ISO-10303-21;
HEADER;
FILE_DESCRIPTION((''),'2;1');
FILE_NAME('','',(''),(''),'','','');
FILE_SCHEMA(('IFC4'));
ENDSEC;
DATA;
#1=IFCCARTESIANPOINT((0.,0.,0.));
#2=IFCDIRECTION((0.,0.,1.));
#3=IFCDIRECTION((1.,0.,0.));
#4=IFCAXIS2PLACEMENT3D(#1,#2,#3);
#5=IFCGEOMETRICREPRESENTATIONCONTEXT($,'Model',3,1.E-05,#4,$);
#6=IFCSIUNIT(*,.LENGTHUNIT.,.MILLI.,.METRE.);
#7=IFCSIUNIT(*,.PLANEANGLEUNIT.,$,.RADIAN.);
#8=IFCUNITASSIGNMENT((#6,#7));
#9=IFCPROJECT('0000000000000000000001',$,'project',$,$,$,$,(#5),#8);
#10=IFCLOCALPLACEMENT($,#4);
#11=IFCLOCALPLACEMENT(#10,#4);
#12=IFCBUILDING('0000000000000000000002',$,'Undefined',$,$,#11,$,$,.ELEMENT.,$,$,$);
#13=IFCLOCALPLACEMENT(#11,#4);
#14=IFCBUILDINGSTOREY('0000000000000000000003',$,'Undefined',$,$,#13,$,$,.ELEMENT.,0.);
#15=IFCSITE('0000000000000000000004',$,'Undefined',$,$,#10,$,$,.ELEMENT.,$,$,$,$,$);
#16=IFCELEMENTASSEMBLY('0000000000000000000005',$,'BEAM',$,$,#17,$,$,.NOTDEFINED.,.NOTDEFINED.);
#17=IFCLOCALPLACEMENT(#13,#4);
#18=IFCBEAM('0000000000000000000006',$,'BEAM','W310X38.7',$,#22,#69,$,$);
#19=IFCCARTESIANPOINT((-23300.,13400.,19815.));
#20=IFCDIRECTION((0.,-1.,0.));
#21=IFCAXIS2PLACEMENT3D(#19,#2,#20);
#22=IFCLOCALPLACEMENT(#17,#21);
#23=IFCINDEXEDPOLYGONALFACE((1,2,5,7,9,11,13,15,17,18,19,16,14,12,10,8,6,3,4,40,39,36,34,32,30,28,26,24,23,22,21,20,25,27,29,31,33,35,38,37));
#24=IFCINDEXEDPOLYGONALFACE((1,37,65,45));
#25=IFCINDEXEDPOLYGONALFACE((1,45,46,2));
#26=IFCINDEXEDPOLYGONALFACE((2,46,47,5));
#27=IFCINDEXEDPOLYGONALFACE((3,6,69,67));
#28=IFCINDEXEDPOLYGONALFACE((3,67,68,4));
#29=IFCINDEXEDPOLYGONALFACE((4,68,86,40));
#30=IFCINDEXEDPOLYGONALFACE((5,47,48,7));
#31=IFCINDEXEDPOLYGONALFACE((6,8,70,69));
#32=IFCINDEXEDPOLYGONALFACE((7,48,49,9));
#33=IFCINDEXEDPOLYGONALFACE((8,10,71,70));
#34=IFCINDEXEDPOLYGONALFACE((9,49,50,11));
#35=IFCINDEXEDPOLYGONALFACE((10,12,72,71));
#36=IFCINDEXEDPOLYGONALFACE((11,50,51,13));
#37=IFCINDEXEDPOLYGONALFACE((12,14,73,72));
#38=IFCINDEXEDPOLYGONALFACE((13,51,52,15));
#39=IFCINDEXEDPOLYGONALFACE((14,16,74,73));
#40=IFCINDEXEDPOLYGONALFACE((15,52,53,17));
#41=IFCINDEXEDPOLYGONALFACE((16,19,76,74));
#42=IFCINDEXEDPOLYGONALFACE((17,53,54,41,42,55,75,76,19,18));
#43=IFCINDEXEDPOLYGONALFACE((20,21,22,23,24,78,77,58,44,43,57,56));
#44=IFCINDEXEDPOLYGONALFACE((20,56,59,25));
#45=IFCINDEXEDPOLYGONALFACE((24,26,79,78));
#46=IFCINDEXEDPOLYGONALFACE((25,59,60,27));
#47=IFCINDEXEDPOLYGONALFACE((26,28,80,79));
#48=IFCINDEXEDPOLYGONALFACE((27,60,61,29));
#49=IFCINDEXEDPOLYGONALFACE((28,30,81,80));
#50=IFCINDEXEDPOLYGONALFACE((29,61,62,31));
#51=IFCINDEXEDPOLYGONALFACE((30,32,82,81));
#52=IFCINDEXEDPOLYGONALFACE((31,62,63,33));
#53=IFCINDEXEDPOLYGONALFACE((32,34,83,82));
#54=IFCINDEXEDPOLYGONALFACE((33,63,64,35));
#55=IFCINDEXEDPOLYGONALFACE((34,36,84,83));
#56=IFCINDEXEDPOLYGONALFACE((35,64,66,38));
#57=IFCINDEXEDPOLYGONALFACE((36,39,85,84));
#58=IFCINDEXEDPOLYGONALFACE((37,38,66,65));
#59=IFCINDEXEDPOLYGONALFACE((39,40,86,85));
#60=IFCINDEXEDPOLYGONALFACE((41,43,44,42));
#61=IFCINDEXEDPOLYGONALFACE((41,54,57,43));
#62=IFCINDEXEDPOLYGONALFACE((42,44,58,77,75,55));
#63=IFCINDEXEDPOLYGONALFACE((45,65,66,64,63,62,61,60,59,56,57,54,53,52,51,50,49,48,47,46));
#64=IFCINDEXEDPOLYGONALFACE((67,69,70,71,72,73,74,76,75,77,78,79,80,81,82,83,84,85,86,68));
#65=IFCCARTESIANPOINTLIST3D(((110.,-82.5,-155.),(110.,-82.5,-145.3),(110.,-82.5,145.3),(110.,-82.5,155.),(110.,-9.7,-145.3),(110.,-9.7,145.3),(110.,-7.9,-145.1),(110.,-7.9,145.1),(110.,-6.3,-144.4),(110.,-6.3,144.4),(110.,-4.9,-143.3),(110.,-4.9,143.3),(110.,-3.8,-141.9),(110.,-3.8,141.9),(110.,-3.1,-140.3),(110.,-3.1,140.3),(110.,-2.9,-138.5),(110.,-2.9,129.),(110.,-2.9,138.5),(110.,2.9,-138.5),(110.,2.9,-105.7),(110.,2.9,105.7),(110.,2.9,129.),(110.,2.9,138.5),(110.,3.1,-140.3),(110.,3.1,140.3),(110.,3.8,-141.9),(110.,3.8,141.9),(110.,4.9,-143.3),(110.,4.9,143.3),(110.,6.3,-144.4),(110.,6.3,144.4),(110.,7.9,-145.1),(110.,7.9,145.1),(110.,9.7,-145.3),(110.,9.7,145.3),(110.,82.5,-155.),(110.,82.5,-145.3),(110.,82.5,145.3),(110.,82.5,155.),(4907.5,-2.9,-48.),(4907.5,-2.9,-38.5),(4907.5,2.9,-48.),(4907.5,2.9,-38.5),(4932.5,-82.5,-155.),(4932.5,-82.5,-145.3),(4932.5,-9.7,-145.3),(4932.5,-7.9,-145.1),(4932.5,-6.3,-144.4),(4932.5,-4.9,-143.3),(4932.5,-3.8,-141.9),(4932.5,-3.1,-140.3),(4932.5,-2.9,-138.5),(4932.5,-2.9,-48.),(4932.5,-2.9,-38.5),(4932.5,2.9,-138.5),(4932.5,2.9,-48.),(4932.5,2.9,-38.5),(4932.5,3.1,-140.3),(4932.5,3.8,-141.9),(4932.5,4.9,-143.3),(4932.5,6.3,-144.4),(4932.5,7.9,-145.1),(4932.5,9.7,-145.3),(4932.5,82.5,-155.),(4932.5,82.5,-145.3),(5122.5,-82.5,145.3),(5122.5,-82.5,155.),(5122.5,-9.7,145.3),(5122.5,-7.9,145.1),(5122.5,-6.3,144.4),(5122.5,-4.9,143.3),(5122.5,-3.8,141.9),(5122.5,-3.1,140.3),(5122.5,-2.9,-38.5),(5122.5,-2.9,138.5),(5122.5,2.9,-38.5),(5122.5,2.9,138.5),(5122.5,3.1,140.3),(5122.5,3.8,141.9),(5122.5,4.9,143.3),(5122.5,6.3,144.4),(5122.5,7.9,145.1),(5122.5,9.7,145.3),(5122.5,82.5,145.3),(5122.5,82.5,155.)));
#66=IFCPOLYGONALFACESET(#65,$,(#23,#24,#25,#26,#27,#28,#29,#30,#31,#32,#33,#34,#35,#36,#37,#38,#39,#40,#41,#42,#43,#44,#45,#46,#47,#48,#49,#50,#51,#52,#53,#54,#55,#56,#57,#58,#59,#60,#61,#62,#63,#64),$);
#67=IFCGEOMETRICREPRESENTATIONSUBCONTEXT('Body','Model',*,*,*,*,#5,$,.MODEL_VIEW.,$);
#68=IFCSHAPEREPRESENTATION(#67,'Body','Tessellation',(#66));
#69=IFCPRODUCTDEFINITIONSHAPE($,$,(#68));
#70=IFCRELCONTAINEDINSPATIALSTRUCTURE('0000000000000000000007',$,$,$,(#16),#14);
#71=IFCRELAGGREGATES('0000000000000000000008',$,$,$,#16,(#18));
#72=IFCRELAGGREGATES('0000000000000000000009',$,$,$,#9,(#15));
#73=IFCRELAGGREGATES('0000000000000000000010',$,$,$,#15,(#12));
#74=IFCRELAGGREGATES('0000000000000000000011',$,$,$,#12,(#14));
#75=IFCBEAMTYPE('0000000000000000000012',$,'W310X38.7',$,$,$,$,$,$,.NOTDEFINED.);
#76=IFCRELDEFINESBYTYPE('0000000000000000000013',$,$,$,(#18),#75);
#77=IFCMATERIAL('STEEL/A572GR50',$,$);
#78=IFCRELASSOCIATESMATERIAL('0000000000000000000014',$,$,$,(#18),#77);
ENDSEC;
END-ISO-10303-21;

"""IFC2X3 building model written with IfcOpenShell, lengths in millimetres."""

from ifc_helpers import new_model, si_unit, frame, origin_with_axes, origin_2d_with_axis, place, context, subcontext, project, spatial, polyline, rectangle, i_section, outline, extrude, boolean, halfspace, material, type_object, element, aggregate, save


model = new_model("IFC2X3")

# Units and contexts
model_context = context("Model", 3, precision=1e-05, world=origin_with_axes())
body_context = subcontext(model_context, "Body", "Model", "MODEL_VIEW")
ifc_project = project(units=[si_unit("LENGTHUNIT", "METRE", prefix="MILLI"), si_unit("PLANEANGLEUNIT", "RADIAN")], contexts=[model_context])

# Site, building, storey
site_placement = place(None, origin_with_axes())
site = spatial("IfcSite", under=ifc_project, at=site_placement, Name="Undefined", CompositionType="ELEMENT")
building_placement = place(site_placement, origin_with_axes())
building = spatial("IfcBuilding", under=site, at=building_placement, Name="Undefined", CompositionType="ELEMENT")
storey_placement = place(building_placement, origin_with_axes())
storey = spatial("IfcBuildingStorey", under=building, at=storey_placement, Name="Undefined", CompositionType="ELEMENT", Elevation=0.0)

# Shared definitions
ifc_material_1 = material(Name="STEEL/A572GR50")

# Element assembly, beam
assembly_1_placement = place(storey_placement, origin_with_axes())
assembly_1 = element("IfcElementAssembly", 1, at=assembly_1_placement, inside=storey, Name="BEAM", AssemblyPlace="NOTDEFINED", PredefinedType="NOTDEFINED")
beam_type_1 = type_object("IfcBeamType", Name="W310X38.7", PredefinedType="NOTDEFINED")
beam_1_placement = place(assembly_1_placement, frame((-23300.0, 13400.0, 19815.0), z_axis=(0.0, 0.0, 1.0), x_axis=(0.0, -1.0, 0.0)))
beam_1 = element("IfcBeam", 2, at=beam_1_placement, type_object=beam_type_1, material=ifc_material_1, Name="BEAM", Description="W310X38.7", context=body_context, shape_type="CSG", body=[
    boolean("DIFFERENCE", boolean("DIFFERENCE", boolean("DIFFERENCE", boolean("DIFFERENCE", boolean("DIFFERENCE", boolean("DIFFERENCE", extrude(i_section(OverallWidth=165.0, OverallDepth=310.0, WebThickness=5.8, FlangeThickness=9.7, FilletRadius=6.8, at=origin_2d_with_axis()), frame((5122.5, 0.0, 0.0), z_axis=(-1.0, 0.0, 0.0), x_axis=(0.0, -1.0, 0.0)), (0.0, 0.0, 1.0), 5122.5), extrude(outline(polyline([(0.0, 0.0), (121.5, 0.0), (121.5, 190.0), (0.0, 190.0), (0.0, 0.0)])), frame((5122.5, -87.5, -38.5), z_axis=(0.0, 1.0, 0.0), x_axis=(0.0, 0.0, -1.0)), (0.0, 0.0, 1.0), 175.0)), extrude(rectangle(XDim=9.5, YDim=165.0, at=origin_2d_with_axis()), frame((4907.5, 0.0, -43.2), z_axis=(1.0, 0.0, 0.0), x_axis=(0.0, 0.0, -1.0)), (0.0, 0.0, 1.0), 215.0)), extrude(outline(polyline([(0.0, 0.0), (36.0, 0.0), (36.0, 10.0), (0.0, 10.0), (0.0, 0.0)])), frame((110.0, 92.5, 129.0), z_axis=(0.0, -1.0, 0.0), x_axis=(0.0, 0.0, 1.0)), (0.0, 0.0, 1.0), 185.0)), extrude(rectangle(XDim=176.0, YDim=176.0, at=origin_2d_with_axis()), frame((92.0, 90.9, 105.7), z_axis=(0.0, 0.0, -1.0), x_axis=(1.0, 0.0, 0.0)), (0.0, 0.0, 1.0), 211.5)), halfspace(frame((5122.5, 0.0, 0.0), z_axis=(-1.0, 0.0, 0.0), x_axis=(0.0, 1.0, 0.0)), True)), halfspace(frame((110.0, 0.0, 255.0), z_axis=(-1.0, 0.0, 0.0), x_axis=(0.0, -1.0, 0.0)), False)),
])

aggregate(assembly_1, [beam_1])

save(model, "model.ifc")
